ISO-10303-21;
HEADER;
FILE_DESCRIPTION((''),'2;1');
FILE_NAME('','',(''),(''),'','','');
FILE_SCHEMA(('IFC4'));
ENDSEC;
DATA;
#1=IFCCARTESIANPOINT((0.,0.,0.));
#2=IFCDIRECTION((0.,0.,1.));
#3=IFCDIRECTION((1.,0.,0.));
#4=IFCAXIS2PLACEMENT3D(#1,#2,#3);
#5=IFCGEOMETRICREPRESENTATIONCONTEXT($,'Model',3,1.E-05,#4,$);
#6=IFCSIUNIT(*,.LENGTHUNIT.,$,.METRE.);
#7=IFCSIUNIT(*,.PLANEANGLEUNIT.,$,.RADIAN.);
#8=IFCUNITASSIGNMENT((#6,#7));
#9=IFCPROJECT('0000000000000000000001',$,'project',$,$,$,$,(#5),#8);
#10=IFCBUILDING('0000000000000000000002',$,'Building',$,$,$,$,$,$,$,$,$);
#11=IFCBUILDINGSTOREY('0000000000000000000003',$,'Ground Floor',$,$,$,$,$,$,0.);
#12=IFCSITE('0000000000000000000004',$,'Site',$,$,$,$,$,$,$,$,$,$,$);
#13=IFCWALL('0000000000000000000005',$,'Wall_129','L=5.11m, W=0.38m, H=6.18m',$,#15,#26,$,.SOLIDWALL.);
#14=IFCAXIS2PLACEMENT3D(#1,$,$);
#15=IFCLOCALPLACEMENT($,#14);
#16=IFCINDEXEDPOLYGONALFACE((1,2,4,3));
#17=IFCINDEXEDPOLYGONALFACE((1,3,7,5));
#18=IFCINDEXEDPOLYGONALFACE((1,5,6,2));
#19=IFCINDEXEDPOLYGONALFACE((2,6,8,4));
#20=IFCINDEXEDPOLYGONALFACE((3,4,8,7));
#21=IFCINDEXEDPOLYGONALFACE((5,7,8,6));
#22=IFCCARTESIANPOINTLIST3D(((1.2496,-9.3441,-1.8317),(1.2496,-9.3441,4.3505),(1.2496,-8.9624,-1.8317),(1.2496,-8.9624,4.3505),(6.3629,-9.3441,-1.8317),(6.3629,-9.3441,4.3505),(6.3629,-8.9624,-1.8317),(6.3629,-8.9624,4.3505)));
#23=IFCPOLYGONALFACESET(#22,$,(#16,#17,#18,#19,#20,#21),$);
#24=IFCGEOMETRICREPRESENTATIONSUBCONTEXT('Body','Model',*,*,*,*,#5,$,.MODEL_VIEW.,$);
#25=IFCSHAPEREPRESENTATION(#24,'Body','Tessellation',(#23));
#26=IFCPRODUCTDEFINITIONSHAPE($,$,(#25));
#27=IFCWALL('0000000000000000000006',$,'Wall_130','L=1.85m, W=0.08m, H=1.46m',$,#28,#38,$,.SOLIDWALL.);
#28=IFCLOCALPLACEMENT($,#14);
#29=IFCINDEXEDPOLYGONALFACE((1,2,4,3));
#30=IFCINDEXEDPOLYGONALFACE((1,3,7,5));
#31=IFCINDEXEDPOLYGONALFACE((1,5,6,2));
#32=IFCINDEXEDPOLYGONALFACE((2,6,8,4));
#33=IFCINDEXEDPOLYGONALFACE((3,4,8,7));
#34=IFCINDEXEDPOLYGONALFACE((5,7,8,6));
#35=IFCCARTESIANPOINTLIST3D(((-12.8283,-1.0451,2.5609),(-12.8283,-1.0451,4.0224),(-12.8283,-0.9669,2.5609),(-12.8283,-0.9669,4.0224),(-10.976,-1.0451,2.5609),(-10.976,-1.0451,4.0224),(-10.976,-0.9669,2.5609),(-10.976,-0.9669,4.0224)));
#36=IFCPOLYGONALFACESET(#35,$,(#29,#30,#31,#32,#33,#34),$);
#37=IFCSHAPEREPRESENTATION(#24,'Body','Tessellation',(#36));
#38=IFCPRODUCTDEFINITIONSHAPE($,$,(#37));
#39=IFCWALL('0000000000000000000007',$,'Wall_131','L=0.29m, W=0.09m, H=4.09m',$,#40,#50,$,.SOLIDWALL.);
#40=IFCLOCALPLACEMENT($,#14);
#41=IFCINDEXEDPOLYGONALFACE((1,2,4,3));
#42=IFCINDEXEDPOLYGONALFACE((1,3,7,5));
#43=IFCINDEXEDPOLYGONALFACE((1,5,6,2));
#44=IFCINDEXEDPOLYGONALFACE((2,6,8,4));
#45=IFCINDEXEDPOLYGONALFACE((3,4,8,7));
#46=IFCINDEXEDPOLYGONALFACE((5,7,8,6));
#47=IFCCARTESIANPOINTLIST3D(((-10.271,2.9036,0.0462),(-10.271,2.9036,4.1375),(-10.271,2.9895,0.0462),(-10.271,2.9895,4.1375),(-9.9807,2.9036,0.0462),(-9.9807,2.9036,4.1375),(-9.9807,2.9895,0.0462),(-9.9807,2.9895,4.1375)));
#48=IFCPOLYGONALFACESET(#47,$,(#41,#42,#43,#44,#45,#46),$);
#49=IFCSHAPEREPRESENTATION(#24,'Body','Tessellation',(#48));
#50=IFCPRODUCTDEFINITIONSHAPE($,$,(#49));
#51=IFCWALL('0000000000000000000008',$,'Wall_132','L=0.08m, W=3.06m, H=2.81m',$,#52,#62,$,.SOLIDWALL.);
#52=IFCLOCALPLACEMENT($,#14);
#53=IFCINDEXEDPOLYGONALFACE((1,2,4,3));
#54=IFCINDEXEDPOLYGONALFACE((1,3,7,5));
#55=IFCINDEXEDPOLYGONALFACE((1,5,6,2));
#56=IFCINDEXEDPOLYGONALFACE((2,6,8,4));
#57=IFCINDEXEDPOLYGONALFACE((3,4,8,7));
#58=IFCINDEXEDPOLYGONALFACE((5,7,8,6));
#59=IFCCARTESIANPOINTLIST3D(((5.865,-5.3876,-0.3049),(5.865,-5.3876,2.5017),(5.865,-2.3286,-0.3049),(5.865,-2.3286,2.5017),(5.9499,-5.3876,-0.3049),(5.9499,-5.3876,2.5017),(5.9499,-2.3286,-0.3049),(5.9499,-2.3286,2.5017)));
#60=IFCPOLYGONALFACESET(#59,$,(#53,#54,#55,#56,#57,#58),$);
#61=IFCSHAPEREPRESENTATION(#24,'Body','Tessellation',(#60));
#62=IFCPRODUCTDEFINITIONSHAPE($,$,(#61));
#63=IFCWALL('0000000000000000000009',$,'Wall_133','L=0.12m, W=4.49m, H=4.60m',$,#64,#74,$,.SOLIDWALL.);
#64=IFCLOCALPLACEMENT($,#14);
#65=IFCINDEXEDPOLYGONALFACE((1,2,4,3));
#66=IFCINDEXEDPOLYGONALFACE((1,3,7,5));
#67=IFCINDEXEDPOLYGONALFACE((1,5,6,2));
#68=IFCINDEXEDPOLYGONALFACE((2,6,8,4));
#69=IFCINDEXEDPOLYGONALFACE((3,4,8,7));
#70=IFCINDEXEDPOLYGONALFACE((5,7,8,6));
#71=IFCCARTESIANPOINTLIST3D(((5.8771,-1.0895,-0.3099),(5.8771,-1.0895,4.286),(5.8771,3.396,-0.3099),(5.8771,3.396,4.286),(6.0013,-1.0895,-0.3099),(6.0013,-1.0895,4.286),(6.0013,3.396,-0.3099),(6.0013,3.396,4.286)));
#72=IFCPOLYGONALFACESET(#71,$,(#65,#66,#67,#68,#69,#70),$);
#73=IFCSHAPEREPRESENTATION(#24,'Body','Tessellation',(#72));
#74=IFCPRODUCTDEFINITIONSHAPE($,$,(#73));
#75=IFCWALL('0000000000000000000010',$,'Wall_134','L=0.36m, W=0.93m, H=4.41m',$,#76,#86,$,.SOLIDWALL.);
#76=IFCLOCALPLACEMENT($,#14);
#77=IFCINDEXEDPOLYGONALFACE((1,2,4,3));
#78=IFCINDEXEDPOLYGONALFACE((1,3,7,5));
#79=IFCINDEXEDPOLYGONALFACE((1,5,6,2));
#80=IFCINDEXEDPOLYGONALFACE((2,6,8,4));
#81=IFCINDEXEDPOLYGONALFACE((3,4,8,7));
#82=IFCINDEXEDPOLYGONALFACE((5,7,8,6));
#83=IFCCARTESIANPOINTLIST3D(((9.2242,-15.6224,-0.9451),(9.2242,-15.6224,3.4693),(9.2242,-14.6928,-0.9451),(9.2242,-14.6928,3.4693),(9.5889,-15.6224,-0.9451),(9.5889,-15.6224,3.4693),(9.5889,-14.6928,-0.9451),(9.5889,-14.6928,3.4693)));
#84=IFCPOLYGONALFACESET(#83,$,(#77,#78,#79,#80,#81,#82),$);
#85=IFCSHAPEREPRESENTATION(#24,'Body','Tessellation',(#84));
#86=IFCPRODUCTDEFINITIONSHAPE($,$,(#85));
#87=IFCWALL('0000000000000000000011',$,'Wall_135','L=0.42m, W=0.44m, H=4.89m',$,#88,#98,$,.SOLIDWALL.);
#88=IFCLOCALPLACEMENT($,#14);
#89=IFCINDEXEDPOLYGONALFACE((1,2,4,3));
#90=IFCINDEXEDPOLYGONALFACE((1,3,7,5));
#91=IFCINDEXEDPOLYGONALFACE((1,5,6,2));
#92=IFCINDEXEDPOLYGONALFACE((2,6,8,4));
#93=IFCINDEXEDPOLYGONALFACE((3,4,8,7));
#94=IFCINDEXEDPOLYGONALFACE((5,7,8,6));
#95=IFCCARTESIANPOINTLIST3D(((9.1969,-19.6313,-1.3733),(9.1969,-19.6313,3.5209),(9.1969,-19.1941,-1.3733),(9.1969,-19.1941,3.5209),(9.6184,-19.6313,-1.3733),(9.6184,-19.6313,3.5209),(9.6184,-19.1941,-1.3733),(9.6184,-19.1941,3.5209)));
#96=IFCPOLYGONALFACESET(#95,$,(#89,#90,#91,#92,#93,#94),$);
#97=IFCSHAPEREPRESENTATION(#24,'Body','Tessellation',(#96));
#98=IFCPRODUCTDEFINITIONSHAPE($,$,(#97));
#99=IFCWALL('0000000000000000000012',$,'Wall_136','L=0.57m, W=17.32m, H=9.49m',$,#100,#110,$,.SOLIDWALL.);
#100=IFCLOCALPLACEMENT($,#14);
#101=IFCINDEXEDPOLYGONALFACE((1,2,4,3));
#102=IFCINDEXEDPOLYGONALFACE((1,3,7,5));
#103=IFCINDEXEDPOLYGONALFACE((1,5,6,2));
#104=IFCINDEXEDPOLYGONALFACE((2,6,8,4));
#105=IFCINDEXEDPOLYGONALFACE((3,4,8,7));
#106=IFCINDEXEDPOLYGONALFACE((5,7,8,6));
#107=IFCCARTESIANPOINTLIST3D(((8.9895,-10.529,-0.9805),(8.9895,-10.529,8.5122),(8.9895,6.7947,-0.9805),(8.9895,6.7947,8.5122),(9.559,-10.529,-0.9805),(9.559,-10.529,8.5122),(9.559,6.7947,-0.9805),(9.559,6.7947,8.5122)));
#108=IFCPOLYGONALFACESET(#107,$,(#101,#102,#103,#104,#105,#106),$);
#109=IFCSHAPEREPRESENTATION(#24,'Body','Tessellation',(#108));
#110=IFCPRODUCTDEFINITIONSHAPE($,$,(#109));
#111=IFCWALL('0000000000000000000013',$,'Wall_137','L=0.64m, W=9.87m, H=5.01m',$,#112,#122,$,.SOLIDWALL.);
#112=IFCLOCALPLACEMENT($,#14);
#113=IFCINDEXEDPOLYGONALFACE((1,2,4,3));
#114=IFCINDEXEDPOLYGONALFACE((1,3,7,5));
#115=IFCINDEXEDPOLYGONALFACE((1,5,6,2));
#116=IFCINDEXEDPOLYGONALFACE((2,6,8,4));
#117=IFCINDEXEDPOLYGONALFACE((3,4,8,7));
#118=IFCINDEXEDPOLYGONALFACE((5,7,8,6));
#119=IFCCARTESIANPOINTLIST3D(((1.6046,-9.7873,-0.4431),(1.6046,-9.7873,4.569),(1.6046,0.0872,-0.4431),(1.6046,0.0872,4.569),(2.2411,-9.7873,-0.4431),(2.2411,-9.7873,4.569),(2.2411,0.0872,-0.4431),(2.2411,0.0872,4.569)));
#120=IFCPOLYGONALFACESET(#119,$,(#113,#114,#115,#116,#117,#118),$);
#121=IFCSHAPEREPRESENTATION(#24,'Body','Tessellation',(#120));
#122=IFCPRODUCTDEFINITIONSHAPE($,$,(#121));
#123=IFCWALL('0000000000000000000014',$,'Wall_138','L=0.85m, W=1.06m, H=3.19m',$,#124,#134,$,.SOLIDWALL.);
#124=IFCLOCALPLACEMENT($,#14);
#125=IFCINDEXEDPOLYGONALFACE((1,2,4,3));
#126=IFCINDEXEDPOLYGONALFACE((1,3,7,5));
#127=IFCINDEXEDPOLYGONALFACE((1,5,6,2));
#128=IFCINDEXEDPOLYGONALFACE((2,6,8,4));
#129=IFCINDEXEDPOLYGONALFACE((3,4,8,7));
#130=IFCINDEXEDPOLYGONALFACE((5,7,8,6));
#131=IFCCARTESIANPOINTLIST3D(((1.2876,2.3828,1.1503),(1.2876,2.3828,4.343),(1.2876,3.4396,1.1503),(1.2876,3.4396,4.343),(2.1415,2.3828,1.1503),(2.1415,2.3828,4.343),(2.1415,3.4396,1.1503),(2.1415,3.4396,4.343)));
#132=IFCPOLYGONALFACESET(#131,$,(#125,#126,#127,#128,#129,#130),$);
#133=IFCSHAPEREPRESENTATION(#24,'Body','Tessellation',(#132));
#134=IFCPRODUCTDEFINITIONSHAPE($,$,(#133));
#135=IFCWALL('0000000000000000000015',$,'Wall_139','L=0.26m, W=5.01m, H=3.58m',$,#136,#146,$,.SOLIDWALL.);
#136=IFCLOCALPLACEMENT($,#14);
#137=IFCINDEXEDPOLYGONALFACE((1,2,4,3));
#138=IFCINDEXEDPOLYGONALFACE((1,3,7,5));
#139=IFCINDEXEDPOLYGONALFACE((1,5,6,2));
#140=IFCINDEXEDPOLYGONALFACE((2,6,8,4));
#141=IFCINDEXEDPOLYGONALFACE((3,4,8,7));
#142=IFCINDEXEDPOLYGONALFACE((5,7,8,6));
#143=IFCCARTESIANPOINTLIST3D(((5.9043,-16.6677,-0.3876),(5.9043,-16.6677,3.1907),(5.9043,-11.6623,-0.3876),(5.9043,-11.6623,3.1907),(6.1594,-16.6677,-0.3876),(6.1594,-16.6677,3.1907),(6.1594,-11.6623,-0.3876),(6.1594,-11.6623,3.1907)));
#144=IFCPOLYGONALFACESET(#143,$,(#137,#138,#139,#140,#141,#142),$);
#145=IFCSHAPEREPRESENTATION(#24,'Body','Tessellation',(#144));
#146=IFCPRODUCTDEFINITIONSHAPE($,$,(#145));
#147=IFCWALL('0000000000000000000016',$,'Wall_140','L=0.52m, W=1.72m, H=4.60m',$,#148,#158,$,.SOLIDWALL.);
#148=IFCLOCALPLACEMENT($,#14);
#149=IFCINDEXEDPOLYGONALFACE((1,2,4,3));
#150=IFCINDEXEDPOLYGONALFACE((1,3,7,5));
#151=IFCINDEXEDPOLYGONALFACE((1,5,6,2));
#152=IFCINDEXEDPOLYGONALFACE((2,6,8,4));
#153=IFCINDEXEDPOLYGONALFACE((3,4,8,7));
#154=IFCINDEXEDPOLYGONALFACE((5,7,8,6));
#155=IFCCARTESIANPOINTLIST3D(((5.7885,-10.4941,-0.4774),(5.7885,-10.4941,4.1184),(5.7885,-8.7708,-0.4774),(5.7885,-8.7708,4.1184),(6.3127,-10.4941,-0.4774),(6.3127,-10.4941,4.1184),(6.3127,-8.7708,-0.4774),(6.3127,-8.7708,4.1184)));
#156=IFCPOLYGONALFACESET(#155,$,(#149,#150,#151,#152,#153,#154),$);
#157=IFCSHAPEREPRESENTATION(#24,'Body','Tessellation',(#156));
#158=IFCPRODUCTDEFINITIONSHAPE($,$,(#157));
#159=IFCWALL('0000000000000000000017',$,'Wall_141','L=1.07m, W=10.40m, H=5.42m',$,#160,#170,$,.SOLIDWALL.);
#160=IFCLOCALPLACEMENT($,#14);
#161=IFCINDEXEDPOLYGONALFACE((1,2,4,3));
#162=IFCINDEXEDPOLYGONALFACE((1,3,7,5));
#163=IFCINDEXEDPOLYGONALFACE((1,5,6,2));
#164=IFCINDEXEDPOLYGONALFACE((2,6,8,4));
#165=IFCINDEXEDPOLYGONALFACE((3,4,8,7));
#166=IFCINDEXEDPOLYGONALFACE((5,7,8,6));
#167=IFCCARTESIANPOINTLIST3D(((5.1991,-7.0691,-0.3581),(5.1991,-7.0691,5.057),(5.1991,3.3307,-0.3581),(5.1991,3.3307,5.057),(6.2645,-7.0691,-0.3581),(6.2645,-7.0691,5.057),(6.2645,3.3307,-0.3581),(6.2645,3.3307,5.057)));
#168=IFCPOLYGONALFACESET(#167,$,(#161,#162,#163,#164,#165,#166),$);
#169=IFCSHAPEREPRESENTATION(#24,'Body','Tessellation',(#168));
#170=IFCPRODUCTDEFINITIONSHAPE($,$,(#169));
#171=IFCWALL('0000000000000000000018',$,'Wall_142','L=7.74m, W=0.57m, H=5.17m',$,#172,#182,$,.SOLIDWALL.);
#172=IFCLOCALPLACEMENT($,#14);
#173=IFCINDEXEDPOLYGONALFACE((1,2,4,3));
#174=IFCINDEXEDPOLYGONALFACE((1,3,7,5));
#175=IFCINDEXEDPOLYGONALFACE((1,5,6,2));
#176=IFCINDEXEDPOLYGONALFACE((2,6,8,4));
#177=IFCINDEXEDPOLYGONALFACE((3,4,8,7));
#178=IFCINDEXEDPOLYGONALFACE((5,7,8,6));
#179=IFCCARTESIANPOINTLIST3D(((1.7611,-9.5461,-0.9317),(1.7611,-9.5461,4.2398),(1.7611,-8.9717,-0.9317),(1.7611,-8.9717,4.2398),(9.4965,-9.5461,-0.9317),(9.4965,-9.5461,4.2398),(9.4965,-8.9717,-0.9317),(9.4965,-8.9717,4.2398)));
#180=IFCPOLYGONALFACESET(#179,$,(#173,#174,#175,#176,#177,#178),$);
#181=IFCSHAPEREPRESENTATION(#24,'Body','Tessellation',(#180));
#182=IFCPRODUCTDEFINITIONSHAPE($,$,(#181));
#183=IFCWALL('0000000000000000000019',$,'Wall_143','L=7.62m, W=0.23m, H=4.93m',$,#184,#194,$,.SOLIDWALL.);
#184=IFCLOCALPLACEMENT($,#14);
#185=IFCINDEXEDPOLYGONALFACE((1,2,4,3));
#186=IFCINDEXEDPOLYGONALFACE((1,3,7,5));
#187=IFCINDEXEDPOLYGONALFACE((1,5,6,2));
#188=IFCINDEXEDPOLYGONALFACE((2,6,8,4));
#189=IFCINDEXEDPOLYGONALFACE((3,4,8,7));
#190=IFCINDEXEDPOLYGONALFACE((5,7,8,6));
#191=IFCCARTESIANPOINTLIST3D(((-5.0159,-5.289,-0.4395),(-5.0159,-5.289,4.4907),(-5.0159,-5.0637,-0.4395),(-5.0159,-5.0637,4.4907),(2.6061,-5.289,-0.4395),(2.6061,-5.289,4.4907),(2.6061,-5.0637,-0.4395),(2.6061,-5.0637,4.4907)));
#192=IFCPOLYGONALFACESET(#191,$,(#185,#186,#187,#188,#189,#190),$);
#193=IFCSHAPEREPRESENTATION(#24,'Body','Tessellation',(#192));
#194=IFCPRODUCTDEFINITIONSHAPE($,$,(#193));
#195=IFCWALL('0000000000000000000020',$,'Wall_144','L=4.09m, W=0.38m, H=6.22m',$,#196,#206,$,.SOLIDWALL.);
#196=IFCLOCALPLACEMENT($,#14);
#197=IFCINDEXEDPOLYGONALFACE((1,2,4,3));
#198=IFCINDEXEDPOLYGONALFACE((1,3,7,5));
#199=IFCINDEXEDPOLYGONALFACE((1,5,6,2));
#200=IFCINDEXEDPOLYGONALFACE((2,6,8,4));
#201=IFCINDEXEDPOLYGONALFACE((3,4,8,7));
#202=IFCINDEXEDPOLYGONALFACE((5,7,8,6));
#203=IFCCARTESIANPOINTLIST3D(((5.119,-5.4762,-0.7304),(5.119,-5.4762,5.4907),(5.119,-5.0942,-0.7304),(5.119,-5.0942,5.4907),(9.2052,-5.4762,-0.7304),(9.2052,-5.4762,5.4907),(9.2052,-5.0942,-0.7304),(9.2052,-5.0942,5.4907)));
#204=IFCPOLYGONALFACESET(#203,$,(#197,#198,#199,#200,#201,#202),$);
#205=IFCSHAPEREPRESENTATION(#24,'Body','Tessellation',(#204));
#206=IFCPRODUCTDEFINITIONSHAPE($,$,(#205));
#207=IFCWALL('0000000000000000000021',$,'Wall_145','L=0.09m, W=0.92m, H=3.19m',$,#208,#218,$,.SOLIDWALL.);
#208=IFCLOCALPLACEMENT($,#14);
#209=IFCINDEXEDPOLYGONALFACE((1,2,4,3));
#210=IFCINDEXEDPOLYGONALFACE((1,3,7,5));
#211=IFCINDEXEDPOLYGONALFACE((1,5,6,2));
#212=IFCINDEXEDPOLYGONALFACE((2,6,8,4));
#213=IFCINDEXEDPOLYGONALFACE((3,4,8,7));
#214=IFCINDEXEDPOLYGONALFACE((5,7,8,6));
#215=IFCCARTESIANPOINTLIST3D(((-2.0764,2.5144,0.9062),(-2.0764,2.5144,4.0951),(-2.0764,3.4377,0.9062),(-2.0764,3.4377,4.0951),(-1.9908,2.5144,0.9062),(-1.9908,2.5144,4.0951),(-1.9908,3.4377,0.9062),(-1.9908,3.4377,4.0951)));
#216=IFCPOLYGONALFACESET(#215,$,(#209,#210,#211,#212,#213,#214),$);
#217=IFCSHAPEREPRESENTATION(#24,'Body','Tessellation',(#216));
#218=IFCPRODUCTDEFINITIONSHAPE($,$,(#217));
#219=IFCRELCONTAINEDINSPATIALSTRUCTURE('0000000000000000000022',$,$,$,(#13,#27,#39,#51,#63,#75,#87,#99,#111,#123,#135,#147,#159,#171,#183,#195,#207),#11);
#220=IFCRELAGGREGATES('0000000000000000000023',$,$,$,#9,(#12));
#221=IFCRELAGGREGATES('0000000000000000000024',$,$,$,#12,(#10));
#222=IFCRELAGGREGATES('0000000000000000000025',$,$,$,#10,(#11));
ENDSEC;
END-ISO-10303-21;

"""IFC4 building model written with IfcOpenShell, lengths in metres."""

from ifc_helpers import new_model, si_unit, frame, origin_with_axes, origin_2d, context, subcontext, project, spatial, rectangle, extrude, element, save


model = new_model("IFC4")

# Units and contexts
model_context = context("Model", 3, precision=1e-05, world=origin_with_axes())
body_context = subcontext(model_context, "Body", "Model", "MODEL_VIEW")
ifc_project = project(units=[si_unit("LENGTHUNIT", "METRE"), si_unit("PLANEANGLEUNIT", "RADIAN")], contexts=[model_context])

# Site, building, storey
site = spatial("IfcSite", under=ifc_project, Name="Site")
building = spatial("IfcBuilding", under=site, Name="Building")
storey = spatial("IfcBuildingStorey", under=building, Name="Ground Floor", Elevation=0.0)

# Walls
element("IfcWall", 1, inside=storey, Name="Wall_129", Description="L=5.11m, W=0.38m, H=6.18m", PredefinedType="SOLIDWALL", context=body_context, shape_type="SweptSolid", body=[
    extrude(rectangle(XDim=5.1133, YDim=0.3817, at=origin_2d()), frame((3.8063, -9.1532, -1.8317), z_axis=(0.0, 0.0, 1.0), x_axis=(1.0, 0.0, 0.0)), (0.0, 0.0, 1.0), 6.1822),
])
element("IfcWall", 2, inside=storey, Name="Wall_130", Description="L=1.85m, W=0.08m, H=1.46m", PredefinedType="SOLIDWALL", context=body_context, shape_type="SweptSolid", body=[
    extrude(rectangle(XDim=1.8523, YDim=0.0783, at=origin_2d()), frame((-11.9021, -1.006, 2.5609), z_axis=(0.0, 0.0, 1.0), x_axis=(1.0, 0.0, 0.0)), (0.0, 0.0, 1.0), 1.4615),
])
element("IfcWall", 3, inside=storey, Name="Wall_131", Description="L=0.29m, W=0.09m, H=4.09m", PredefinedType="SOLIDWALL", context=body_context, shape_type="SweptSolid", body=[
    extrude(rectangle(XDim=0.2903, YDim=0.0859, at=origin_2d()), frame((-10.1258, 2.9466, 0.0462), z_axis=(0.0, 0.0, 1.0), x_axis=(1.0, 0.0, 0.0)), (0.0, 0.0, 1.0), 4.0912),
])
element("IfcWall", 4, inside=storey, Name="Wall_132", Description="L=0.08m, W=3.06m, H=2.81m", PredefinedType="SOLIDWALL", context=body_context, shape_type="SweptSolid", body=[
    extrude(rectangle(XDim=0.0849, YDim=3.059, at=origin_2d()), frame((5.9074, -3.8581, -0.3049), z_axis=(0.0, 0.0, 1.0), x_axis=(1.0, 0.0, 0.0)), (0.0, 0.0, 1.0), 2.8066),
])
element("IfcWall", 5, inside=storey, Name="Wall_133", Description="L=0.12m, W=4.49m, H=4.60m", PredefinedType="SOLIDWALL", context=body_context, shape_type="SweptSolid", body=[
    extrude(rectangle(XDim=0.1242, YDim=4.4854, at=origin_2d()), frame((5.9392, 1.1533, -0.3099), z_axis=(0.0, 0.0, 1.0), x_axis=(1.0, 0.0, 0.0)), (0.0, 0.0, 1.0), 4.5959),
])
element("IfcWall", 6, inside=storey, Name="Wall_134", Description="L=0.36m, W=0.93m, H=4.41m", PredefinedType="SOLIDWALL", context=body_context, shape_type="SweptSolid", body=[
    extrude(rectangle(XDim=0.3647, YDim=0.9296, at=origin_2d()), frame((9.4065, -15.1576, -0.9451), z_axis=(0.0, 0.0, 1.0), x_axis=(1.0, 0.0, 0.0)), (0.0, 0.0, 1.0), 4.4145),
])
element("IfcWall", 7, inside=storey, Name="Wall_135", Description="L=0.42m, W=0.44m, H=4.89m", PredefinedType="SOLIDWALL", context=body_context, shape_type="SweptSolid", body=[
    extrude(rectangle(XDim=0.4215, YDim=0.4372, at=origin_2d()), frame((9.4076, -19.4127, -1.3733), z_axis=(0.0, 0.0, 1.0), x_axis=(1.0, 0.0, 0.0)), (0.0, 0.0, 1.0), 4.8942),
])
element("IfcWall", 8, inside=storey, Name="Wall_136", Description="L=0.57m, W=17.32m, H=9.49m", PredefinedType="SOLIDWALL", context=body_context, shape_type="SweptSolid", body=[
    extrude(rectangle(XDim=0.5695, YDim=17.3237, at=origin_2d()), frame((9.2742, -1.8671, -0.9805), z_axis=(0.0, 0.0, 1.0), x_axis=(1.0, 0.0, 0.0)), (0.0, 0.0, 1.0), 9.4927),
])
element("IfcWall", 9, inside=storey, Name="Wall_137", Description="L=0.64m, W=9.87m, H=5.01m", PredefinedType="SOLIDWALL", context=body_context, shape_type="SweptSolid", body=[
    extrude(rectangle(XDim=0.6365, YDim=9.8745, at=origin_2d()), frame((1.9229, -4.8501, -0.4431), z_axis=(0.0, 0.0, 1.0), x_axis=(1.0, 0.0, 0.0)), (0.0, 0.0, 1.0), 5.0121),
])
element("IfcWall", 10, inside=storey, Name="Wall_138", Description="L=0.85m, W=1.06m, H=3.19m", PredefinedType="SOLIDWALL", context=body_context, shape_type="SweptSolid", body=[
    extrude(rectangle(XDim=0.8539, YDim=1.0568, at=origin_2d()), frame((1.7145, 2.9112, 1.1503), z_axis=(0.0, 0.0, 1.0), x_axis=(1.0, 0.0, 0.0)), (0.0, 0.0, 1.0), 3.1927),
])
element("IfcWall", 11, inside=storey, Name="Wall_139", Description="L=0.26m, W=5.01m, H=3.58m", PredefinedType="SOLIDWALL", context=body_context, shape_type="SweptSolid", body=[
    extrude(rectangle(XDim=0.255, YDim=5.0054, at=origin_2d()), frame((6.0319, -14.165, -0.3876), z_axis=(0.0, 0.0, 1.0), x_axis=(1.0, 0.0, 0.0)), (0.0, 0.0, 1.0), 3.5783),
])
element("IfcWall", 12, inside=storey, Name="Wall_140", Description="L=0.52m, W=1.72m, H=4.60m", PredefinedType="SOLIDWALL", context=body_context, shape_type="SweptSolid", body=[
    extrude(rectangle(XDim=0.5242, YDim=1.7233, at=origin_2d()), frame((6.0506, -9.6325, -0.4774), z_axis=(0.0, 0.0, 1.0), x_axis=(1.0, 0.0, 0.0)), (0.0, 0.0, 1.0), 4.5957),
])
element("IfcWall", 13, inside=storey, Name="Wall_141", Description="L=1.07m, W=10.40m, H=5.42m", PredefinedType="SOLIDWALL", context=body_context, shape_type="SweptSolid", body=[
    extrude(rectangle(XDim=1.0655, YDim=10.3998, at=origin_2d()), frame((5.7318, -1.8692, -0.3581), z_axis=(0.0, 0.0, 1.0), x_axis=(1.0, 0.0, 0.0)), (0.0, 0.0, 1.0), 5.415),
])
element("IfcWall", 14, inside=storey, Name="Wall_142", Description="L=7.74m, W=0.57m, H=5.17m", PredefinedType="SOLIDWALL", context=body_context, shape_type="SweptSolid", body=[
    extrude(rectangle(XDim=7.7353, YDim=0.5744, at=origin_2d()), frame((5.6288, -9.2589, -0.9317), z_axis=(0.0, 0.0, 1.0), x_axis=(1.0, 0.0, 0.0)), (0.0, 0.0, 1.0), 5.1715),
])
element("IfcWall", 15, inside=storey, Name="Wall_143", Description="L=7.62m, W=0.23m, H=4.93m", PredefinedType="SOLIDWALL", context=body_context, shape_type="SweptSolid", body=[
    extrude(rectangle(XDim=7.622, YDim=0.2253, at=origin_2d()), frame((-1.2049, -5.1763, -0.4395), z_axis=(0.0, 0.0, 1.0), x_axis=(1.0, 0.0, 0.0)), (0.0, 0.0, 1.0), 4.9302),
])
element("IfcWall", 16, inside=storey, Name="Wall_144", Description="L=4.09m, W=0.38m, H=6.22m", PredefinedType="SOLIDWALL", context=body_context, shape_type="SweptSolid", body=[
    extrude(rectangle(XDim=4.0862, YDim=0.382, at=origin_2d()), frame((7.1621, -5.2852, -0.7304), z_axis=(0.0, 0.0, 1.0), x_axis=(1.0, 0.0, 0.0)), (0.0, 0.0, 1.0), 6.221),
])
element("IfcWall", 17, inside=storey, Name="Wall_145", Description="L=0.09m, W=0.92m, H=3.19m", PredefinedType="SOLIDWALL", context=body_context, shape_type="SweptSolid", body=[
    extrude(rectangle(XDim=0.0856, YDim=0.9233, at=origin_2d()), frame((-2.0336, 2.9761, 0.9062), z_axis=(0.0, 0.0, 1.0), x_axis=(1.0, 0.0, 0.0)), (0.0, 0.0, 1.0), 3.1889),
])

save(model, "model.ifc")
